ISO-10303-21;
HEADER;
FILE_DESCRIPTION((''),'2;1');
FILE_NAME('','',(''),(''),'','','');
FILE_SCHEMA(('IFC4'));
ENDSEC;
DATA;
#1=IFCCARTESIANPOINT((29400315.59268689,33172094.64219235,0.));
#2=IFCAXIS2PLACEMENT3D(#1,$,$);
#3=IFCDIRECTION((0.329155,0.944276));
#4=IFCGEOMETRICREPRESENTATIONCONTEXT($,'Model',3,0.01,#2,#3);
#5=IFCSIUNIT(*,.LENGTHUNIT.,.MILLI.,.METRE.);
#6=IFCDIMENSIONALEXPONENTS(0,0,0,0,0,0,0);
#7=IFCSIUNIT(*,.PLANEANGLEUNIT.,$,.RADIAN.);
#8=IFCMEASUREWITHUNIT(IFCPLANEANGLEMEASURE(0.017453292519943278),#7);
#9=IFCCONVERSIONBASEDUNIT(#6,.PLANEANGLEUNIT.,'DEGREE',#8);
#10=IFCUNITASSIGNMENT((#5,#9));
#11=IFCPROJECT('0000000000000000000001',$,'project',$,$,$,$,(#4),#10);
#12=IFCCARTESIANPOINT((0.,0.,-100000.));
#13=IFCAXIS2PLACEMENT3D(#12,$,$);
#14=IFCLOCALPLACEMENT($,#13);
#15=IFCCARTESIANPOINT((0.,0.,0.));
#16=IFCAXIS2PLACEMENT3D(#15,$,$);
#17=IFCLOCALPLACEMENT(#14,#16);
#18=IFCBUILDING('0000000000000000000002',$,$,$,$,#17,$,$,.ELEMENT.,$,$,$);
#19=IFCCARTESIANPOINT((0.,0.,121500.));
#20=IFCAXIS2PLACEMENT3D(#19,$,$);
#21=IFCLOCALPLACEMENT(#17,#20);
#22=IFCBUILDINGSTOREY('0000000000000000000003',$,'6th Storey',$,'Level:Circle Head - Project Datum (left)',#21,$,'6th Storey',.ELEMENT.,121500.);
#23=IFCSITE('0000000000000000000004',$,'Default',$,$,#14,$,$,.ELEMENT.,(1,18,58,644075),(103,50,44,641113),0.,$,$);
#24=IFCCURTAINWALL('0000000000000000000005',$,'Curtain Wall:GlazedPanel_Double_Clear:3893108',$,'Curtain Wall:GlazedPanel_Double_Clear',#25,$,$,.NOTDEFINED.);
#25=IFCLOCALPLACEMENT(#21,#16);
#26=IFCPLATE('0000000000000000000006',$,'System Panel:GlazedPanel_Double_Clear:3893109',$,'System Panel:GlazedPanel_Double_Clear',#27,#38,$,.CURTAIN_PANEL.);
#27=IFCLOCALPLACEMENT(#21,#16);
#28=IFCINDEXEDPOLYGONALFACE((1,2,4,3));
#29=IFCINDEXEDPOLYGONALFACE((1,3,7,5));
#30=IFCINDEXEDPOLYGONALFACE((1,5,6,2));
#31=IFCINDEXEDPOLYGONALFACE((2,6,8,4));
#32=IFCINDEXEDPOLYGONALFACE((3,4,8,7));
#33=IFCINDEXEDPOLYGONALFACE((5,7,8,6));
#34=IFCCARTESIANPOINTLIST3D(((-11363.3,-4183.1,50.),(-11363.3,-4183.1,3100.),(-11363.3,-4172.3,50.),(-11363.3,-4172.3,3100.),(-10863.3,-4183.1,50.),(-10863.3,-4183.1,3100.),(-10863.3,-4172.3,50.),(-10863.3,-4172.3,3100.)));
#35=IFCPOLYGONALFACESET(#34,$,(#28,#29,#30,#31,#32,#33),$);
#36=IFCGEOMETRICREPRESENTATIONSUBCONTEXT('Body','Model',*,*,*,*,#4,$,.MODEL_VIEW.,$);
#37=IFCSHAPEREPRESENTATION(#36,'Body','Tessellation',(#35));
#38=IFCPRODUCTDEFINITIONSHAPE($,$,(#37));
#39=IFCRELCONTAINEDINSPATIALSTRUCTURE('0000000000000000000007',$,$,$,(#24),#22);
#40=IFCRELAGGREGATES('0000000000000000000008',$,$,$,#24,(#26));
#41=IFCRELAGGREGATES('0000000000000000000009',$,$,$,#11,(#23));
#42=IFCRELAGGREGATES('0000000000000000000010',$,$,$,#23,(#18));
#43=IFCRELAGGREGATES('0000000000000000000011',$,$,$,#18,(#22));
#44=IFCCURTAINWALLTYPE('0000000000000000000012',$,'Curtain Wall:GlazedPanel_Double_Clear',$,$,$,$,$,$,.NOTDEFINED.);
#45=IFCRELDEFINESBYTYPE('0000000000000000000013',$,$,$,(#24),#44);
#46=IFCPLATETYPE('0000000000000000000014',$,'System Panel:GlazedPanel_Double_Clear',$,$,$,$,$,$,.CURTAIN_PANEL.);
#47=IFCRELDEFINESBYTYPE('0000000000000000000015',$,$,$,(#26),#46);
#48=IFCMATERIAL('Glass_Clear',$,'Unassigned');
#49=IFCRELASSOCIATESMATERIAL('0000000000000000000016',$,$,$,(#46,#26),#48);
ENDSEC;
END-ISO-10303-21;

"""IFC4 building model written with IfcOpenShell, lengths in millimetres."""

from ifc_helpers import new_model, entity, si_unit, converted_unit, direction, frame, origin, place, context, subcontext, project, spatial, indexed_curve, outline, extrude, source, transform, mapped, material, type_object, type_shapes, element, aggregate, save


model = new_model("IFC4")

# Units and contexts
model_context = context("Model", 3, precision=0.01, world=frame((29400315.59268689, 33172094.64219235, 0.0)), true_north=direction((0.329155, 0.944276)))
body_context = subcontext(model_context, "Body", "Model", "MODEL_VIEW")
ifc_project = project(units=[si_unit("LENGTHUNIT", "METRE", prefix="MILLI"), converted_unit("PLANEANGLEUNIT", "DEGREE", entity("IfcPlaneAngleMeasure", 0.017453292519943278), si_unit("PLANEANGLEUNIT", "RADIAN"), dimensions=[0, 0, 0, 0, 0, 0, 0])], contexts=[model_context])

# Site, building, storey
site_placement = place(None, frame((0.0, 0.0, -100000.0)))
site = spatial("IfcSite", under=ifc_project, at=site_placement, Name="Default", CompositionType="ELEMENT", RefLatitude=(1, 18, 58, 644075), RefLongitude=(103, 50, 44, 641113), RefElevation=0.0)
building_placement = place(site_placement, origin())
building = spatial("IfcBuilding", under=site, at=building_placement, CompositionType="ELEMENT")
storey_placement = place(building_placement, frame((0.0, 0.0, 121500.0)))
storey = spatial("IfcBuildingStorey", under=building, at=storey_placement, Name="6th Storey", ObjectType="Level:Circle Head - Project Datum (left)", LongName="6th Storey", CompositionType="ELEMENT", Elevation=121500.0)

# Shared definitions
curtain_wall_type = type_object("IfcCurtainWallType", Name="Curtain Wall:GlazedPanel_Double_Clear", PredefinedType="NOTDEFINED")
ifc_material_1 = material(Name="Glass_Clear", Category="Unassigned")

# Curtain wall, plate
curtain_wall_1_placement = place(storey_placement, frame((0.0, 0.0, -121500.0)))
curtain_wall_1 = element("IfcCurtainWall", 1, at=curtain_wall_1_placement, inside=storey, type_object=curtain_wall_type, Name="Curtain Wall:GlazedPanel_Double_Clear:3893108", ObjectType="Curtain Wall:GlazedPanel_Double_Clear", PredefinedType="NOTDEFINED")
plate_type_1 = type_object("IfcPlateType", Name="System Panel:GlazedPanel_Double_Clear", PredefinedType="CURTAIN_PANEL", material=ifc_material_1)
shared_shape_1 = source(origin(), body_context, "Body", "SweptSolid", [
    extrude(outline(indexed_curve([(-5.4, -250.0), (5.4, -250.0), (5.4, 250.0), (-5.4, 250.0), (-5.4, -250.0)], self_intersect=False)), frame((0.0, -111.0, 0.0), z_axis=(0.0, 0.0, 1.0), x_axis=(0.0, 1.0, 0.0)), (0.0, 0.0, 1.0), 3050.0),
])
type_shapes(plate_type_1, [shared_shape_1])
plate_1_placement = place(curtain_wall_1_placement, frame((-11113.3, -4066.7, 121550.0)))
plate_1 = element("IfcPlate", 2, at=plate_1_placement, type_object=plate_type_1, material=ifc_material_1, Name="System Panel:GlazedPanel_Double_Clear:3893109", ObjectType="System Panel:GlazedPanel_Double_Clear", PredefinedType="CURTAIN_PANEL", context=body_context, shape_type="MappedRepresentation", body=[
    mapped(shared_shape_1, transform((0.0, 0.0, 0.0), scale=1.0)),
])
aggregate(curtain_wall_1, [plate_1])

save(model, "model.ifc")
